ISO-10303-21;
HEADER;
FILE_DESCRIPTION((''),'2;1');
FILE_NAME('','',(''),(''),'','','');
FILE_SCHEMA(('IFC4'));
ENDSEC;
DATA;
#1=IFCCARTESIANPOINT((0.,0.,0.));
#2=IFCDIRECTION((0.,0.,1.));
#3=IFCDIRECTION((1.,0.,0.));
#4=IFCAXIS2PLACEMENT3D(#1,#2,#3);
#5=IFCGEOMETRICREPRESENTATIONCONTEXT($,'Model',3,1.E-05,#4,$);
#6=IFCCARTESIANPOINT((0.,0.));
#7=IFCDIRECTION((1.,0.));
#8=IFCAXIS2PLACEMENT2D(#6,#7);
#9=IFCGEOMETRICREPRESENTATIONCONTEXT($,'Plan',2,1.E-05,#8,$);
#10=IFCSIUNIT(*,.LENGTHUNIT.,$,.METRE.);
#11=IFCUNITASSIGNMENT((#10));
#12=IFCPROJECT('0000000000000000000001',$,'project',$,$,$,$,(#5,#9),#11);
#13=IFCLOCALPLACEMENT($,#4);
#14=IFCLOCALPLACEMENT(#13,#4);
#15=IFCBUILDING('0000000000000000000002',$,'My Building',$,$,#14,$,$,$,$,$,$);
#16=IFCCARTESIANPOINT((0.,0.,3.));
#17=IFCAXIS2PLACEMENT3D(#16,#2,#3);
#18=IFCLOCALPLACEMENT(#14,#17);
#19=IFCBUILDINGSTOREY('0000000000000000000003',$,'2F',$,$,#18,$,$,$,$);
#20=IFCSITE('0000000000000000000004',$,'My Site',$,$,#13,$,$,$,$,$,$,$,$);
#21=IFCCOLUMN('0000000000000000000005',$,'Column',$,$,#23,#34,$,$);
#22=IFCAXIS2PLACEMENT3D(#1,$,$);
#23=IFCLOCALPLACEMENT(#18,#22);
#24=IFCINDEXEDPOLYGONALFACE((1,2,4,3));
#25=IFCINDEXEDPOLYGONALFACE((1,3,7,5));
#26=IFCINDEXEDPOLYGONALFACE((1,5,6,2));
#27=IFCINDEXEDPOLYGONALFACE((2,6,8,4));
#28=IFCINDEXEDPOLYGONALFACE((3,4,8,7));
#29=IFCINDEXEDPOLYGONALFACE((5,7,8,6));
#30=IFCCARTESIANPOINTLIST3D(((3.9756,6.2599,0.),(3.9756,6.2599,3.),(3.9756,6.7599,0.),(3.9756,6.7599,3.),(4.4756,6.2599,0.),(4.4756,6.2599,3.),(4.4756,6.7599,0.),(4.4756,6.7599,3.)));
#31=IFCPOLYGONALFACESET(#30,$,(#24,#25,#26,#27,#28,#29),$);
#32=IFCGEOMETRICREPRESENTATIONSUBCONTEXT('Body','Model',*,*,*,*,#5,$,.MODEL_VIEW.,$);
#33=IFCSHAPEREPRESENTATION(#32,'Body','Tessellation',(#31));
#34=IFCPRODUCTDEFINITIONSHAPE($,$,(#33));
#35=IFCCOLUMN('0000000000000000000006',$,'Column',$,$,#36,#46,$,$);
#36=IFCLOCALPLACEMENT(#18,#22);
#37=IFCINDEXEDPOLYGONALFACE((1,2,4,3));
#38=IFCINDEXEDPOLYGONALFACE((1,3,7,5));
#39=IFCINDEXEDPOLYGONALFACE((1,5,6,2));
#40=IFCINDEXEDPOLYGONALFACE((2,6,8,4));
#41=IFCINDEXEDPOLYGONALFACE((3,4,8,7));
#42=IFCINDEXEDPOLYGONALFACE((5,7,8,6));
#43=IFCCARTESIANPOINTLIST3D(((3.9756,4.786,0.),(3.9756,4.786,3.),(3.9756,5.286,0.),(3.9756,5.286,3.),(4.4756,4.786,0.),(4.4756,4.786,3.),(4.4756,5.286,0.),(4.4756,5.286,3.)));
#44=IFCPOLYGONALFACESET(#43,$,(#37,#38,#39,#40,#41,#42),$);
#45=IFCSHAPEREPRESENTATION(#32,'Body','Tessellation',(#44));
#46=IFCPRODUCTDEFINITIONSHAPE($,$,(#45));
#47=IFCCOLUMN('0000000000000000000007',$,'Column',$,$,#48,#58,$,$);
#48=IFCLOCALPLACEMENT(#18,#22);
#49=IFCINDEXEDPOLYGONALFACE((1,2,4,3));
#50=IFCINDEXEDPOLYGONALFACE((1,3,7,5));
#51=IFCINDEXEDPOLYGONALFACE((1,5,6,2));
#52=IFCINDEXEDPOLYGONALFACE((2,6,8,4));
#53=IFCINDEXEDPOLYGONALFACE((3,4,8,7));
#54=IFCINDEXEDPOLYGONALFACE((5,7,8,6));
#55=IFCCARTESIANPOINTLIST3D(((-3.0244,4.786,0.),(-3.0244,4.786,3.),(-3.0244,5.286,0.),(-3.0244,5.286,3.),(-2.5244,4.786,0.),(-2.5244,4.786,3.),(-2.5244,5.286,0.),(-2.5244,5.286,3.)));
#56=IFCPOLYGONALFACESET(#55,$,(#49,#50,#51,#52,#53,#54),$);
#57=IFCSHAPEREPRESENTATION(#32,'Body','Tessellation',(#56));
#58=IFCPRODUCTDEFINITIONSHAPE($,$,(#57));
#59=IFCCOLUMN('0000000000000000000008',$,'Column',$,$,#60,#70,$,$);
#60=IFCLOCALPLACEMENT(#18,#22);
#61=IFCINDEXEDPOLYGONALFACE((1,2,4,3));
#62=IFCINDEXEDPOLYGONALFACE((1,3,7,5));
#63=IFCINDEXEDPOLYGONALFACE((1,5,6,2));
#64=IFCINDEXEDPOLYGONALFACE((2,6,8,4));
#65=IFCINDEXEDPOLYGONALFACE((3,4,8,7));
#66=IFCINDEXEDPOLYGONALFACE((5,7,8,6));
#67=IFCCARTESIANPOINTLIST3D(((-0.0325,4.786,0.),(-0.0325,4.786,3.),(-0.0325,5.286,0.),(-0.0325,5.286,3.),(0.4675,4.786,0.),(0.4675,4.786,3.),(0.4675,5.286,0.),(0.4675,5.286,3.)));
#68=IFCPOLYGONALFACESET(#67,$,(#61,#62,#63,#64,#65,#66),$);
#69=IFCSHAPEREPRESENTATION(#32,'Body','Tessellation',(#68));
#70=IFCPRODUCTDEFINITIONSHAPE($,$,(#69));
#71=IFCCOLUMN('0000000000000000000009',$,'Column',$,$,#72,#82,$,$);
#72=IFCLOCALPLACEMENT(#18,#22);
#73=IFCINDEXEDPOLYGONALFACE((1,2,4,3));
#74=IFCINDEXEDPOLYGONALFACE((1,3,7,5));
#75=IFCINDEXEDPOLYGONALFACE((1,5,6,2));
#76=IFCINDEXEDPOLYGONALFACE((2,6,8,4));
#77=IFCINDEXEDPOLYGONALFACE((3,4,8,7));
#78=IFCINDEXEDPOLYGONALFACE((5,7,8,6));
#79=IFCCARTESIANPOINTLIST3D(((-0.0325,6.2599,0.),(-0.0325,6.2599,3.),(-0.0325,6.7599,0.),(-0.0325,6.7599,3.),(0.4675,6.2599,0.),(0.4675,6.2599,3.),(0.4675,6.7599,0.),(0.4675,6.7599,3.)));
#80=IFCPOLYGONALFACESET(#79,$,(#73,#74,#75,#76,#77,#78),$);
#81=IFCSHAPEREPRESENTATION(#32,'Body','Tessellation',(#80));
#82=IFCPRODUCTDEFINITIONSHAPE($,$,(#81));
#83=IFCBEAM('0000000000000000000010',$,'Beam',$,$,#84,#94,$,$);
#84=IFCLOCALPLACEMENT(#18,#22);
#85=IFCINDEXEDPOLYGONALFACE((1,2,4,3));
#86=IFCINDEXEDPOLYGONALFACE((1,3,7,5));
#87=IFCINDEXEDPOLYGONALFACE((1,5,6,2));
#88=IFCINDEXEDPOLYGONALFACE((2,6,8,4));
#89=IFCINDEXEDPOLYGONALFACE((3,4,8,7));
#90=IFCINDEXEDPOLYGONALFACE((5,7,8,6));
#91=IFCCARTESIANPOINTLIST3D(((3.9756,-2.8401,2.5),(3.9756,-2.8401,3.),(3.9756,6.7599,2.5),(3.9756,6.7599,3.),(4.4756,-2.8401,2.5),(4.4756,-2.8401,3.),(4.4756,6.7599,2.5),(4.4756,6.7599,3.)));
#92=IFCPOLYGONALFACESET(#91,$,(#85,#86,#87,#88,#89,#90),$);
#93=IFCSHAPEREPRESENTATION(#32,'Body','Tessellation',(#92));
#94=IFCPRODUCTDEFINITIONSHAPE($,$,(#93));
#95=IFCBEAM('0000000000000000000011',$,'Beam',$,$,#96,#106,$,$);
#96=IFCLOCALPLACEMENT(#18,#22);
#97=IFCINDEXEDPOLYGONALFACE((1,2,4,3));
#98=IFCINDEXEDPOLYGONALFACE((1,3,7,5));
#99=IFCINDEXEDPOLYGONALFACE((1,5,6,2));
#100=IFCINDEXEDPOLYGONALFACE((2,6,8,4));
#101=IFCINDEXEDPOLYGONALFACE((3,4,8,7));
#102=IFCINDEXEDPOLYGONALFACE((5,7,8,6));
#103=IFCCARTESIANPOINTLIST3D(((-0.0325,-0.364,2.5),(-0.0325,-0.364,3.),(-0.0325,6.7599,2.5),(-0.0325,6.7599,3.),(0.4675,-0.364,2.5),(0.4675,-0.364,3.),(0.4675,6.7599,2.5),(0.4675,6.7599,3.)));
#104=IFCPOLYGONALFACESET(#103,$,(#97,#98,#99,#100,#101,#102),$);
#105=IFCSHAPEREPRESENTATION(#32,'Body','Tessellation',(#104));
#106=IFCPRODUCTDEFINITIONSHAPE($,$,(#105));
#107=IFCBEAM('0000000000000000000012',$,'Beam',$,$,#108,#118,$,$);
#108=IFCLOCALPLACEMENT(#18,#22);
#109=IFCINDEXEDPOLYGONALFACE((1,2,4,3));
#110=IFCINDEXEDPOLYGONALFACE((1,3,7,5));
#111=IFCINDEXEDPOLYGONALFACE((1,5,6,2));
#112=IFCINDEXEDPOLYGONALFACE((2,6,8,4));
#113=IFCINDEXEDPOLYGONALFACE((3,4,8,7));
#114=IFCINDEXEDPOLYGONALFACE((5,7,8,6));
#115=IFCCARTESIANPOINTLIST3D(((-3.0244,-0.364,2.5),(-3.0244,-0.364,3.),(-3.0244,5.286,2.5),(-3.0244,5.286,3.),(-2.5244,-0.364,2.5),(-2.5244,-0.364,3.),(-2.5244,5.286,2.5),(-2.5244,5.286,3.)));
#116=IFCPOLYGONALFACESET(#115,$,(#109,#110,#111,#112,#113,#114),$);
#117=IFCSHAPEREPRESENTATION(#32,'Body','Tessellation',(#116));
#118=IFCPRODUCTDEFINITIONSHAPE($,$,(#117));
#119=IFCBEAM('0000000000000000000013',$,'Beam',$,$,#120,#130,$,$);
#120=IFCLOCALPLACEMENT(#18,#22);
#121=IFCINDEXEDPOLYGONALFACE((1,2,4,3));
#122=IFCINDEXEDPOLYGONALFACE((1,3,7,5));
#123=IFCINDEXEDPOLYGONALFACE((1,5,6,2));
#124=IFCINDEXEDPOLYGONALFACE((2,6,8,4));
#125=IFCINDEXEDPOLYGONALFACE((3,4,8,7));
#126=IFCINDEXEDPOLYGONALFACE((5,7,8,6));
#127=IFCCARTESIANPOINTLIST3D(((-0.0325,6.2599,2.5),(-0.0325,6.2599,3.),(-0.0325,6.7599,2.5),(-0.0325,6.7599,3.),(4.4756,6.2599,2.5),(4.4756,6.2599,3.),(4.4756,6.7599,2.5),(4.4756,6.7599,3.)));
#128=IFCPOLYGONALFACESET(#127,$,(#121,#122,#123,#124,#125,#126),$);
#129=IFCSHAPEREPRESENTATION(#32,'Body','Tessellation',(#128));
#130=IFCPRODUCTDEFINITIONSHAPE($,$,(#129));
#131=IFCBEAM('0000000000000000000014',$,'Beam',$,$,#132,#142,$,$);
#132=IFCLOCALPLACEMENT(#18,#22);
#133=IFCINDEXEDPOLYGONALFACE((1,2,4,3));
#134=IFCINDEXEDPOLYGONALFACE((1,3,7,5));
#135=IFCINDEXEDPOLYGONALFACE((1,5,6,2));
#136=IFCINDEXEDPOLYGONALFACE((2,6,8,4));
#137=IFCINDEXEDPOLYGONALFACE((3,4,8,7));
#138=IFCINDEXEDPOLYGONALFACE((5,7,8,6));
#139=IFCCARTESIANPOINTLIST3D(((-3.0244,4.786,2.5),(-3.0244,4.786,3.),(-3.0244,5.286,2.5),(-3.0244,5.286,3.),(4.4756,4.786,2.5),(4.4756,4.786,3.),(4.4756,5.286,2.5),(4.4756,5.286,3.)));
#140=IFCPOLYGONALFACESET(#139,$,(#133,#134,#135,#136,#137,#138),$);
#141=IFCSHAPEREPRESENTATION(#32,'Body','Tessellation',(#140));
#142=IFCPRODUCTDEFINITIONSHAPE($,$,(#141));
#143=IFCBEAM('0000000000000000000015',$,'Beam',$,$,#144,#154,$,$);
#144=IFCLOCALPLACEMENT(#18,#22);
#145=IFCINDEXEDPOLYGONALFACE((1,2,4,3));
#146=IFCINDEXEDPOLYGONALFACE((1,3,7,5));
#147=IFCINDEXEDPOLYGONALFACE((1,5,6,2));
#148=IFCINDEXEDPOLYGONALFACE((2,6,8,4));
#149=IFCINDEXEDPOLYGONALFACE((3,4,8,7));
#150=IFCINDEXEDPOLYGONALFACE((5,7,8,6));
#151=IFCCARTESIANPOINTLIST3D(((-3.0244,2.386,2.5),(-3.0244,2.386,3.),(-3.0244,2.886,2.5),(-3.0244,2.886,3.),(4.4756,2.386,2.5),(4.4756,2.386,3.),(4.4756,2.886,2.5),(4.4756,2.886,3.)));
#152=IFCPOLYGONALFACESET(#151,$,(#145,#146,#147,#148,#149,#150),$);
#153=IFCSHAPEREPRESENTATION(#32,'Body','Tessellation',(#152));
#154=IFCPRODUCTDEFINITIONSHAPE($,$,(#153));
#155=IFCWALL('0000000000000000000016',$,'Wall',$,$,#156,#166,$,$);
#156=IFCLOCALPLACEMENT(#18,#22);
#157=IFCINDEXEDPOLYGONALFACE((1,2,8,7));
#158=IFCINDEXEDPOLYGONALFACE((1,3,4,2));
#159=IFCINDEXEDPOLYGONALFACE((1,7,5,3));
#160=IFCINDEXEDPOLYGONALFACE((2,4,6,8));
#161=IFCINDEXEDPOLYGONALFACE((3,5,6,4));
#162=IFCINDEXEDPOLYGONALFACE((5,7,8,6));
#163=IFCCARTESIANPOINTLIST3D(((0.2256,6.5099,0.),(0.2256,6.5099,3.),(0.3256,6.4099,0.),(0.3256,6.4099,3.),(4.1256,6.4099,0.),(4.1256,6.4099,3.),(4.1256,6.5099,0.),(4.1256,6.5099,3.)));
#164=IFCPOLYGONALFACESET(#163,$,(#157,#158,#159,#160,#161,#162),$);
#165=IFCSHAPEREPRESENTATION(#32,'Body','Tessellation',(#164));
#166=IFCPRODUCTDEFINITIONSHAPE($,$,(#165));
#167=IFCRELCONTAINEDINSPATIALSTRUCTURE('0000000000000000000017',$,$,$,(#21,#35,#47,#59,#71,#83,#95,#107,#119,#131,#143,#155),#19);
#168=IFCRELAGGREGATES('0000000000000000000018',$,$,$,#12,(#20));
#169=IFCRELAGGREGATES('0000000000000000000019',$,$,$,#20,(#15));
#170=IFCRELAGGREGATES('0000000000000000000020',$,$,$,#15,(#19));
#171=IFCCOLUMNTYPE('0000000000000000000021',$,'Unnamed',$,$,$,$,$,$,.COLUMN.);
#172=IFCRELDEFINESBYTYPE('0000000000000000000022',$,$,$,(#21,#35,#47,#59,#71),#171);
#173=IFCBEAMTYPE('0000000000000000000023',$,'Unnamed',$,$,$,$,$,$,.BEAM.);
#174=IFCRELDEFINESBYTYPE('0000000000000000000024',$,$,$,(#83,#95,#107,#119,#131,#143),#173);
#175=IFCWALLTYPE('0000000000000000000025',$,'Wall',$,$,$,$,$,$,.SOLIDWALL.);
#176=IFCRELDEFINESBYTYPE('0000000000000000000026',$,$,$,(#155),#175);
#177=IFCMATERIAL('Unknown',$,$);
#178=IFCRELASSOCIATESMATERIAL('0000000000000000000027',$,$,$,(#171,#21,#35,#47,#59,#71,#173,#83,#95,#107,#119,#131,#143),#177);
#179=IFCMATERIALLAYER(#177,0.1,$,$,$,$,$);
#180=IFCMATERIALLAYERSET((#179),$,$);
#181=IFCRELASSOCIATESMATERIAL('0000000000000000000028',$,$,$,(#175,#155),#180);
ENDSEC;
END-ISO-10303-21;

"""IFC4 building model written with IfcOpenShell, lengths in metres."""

from ifc_helpers import new_model, si_unit, frame, origin_with_axes, origin_2d_with_axis, place, context, subcontext, project, spatial, line, indexed_curve, rectangle, outline, extrude, material, layer, layer_set, layer_usage, material_profile, profile_set, profile_usage, type_object, element, save


model = new_model("IFC4")

# Units and contexts
model_context = context("Model", 3, precision=1e-05, world=origin_with_axes())
plan_context = context("Plan", 2, precision=1e-05, world=origin_2d_with_axis())
body_context_1 = subcontext(model_context, "Body", "Model", "MODEL_VIEW")
ifc_project = project(units=[si_unit("LENGTHUNIT", "METRE")], contexts=[model_context, plan_context])

# Site, building, storey
site_placement = place(None, origin_with_axes())
site = spatial("IfcSite", under=ifc_project, at=site_placement, Name="My Site")
building_placement = place(site_placement, origin_with_axes())
building = spatial("IfcBuilding", under=site, at=building_placement, Name="My Building")
storey_placement = place(building_placement, frame((0.0, 0.0, 3.0), z_axis=(0.0, 0.0, 1.0), x_axis=(1.0, 0.0, 0.0)))
storey = spatial("IfcBuildingStorey", under=building, at=storey_placement, Name="2F")

# Columns
ifc_material = material(Name="Unknown")
ifc_material_profile_1 = material_profile(ifc_material, rectangle(XDim=0.5, YDim=0.5))
ifc_profile_set_1 = profile_set([ifc_material_profile_1])
ifc_profile_usage_1 = profile_usage(ifc_profile_set_1, cardinal=5)
column_type = type_object("IfcColumnType", Name="Unnamed", PredefinedType="COLUMN", material=ifc_profile_set_1)
column_1_placement = place(storey_placement, frame((4.2256, 6.5099, 0.0), z_axis=(0.0, 0.0, 1.0), x_axis=(1.0, 0.0, 0.0)))
element("IfcColumn", 1, at=column_1_placement, inside=storey, type_object=column_type, material=ifc_profile_usage_1, Name="Column", context=body_context_1, shape_type="SweptSolid", body=[
    extrude(rectangle(XDim=0.5, YDim=0.5), origin_with_axes(), (0.0, 0.0, 1.0), 3.0),
])
ifc_profile_usage_2 = profile_usage(ifc_profile_set_1, cardinal=5)
column_2_placement = place(storey_placement, frame((4.2256, 5.036, 0.0), z_axis=(0.0, 0.0, 1.0), x_axis=(1.0, 0.0, 0.0)))
element("IfcColumn", 2, at=column_2_placement, inside=storey, type_object=column_type, material=ifc_profile_usage_2, Name="Column", context=body_context_1, shape_type="SweptSolid", body=[
    extrude(rectangle(XDim=0.5, YDim=0.5), origin_with_axes(), (0.0, 0.0, 1.0), 3.0),
])
ifc_profile_usage_3 = profile_usage(ifc_profile_set_1, cardinal=5)
column_3_placement = place(storey_placement, frame((-2.7744, 5.036, 0.0), z_axis=(0.0, 0.0, 1.0), x_axis=(1.0, 0.0, 0.0)))
element("IfcColumn", 3, at=column_3_placement, inside=storey, type_object=column_type, material=ifc_profile_usage_3, Name="Column", context=body_context_1, shape_type="SweptSolid", body=[
    extrude(rectangle(XDim=0.5, YDim=0.5), origin_with_axes(), (0.0, 0.0, 1.0), 3.0),
])
ifc_profile_usage_4 = profile_usage(ifc_profile_set_1, cardinal=5)
column_4_placement = place(storey_placement, frame((0.2175, 5.036, 0.0), z_axis=(0.0, 0.0, 1.0), x_axis=(1.0, 0.0, 0.0)))
element("IfcColumn", 4, at=column_4_placement, inside=storey, type_object=column_type, material=ifc_profile_usage_4, Name="Column", context=body_context_1, shape_type="SweptSolid", body=[
    extrude(rectangle(XDim=0.5, YDim=0.5), origin_with_axes(), (0.0, 0.0, 1.0), 3.0),
])
ifc_profile_usage_5 = profile_usage(ifc_profile_set_1, cardinal=5)
column_5_placement = place(storey_placement, frame((0.2175, 6.5099, 0.0), z_axis=(0.0, 0.0, 1.0), x_axis=(1.0, 0.0, 0.0)))
element("IfcColumn", 5, at=column_5_placement, inside=storey, type_object=column_type, material=ifc_profile_usage_5, Name="Column", context=body_context_1, shape_type="SweptSolid", body=[
    extrude(rectangle(XDim=0.5, YDim=0.5), origin_with_axes(), (0.0, 0.0, 1.0), 3.0),
])

# Beams
ifc_material_profile_2 = material_profile(ifc_material, rectangle(XDim=0.5, YDim=0.5))
ifc_profile_set_2 = profile_set([ifc_material_profile_2])
ifc_profile_usage_6 = profile_usage(ifc_profile_set_2, cardinal=7)
beam_type = type_object("IfcBeamType", Name="Unnamed", PredefinedType="BEAM", material=ifc_profile_set_2)
beam_1_placement = place(storey_placement, frame((4.4756, 6.7599, 3.0), z_axis=(0.0, -1.0, 0.0), x_axis=(1.0, 0.0, 0.0)))
element("IfcBeam", 6, at=beam_1_placement, inside=storey, type_object=beam_type, material=ifc_profile_usage_6, Name="Beam", context=body_context_1, shape_type="SweptSolid", body=[
    extrude(rectangle(XDim=0.5, YDim=0.5), frame((-0.25, -0.25, 0.0), z_axis=(0.0, 0.0, 1.0), x_axis=(1.0, 0.0, 0.0)), (0.0, 0.0, 1.0), 9.6),
])
ifc_profile_usage_7 = profile_usage(ifc_profile_set_2, cardinal=7)
beam_2_placement = place(storey_placement, frame((0.4675, 6.7599, 3.0), z_axis=(0.0, -1.0, 0.0), x_axis=(1.0, 0.0, 0.0)))
element("IfcBeam", 7, at=beam_2_placement, inside=storey, type_object=beam_type, material=ifc_profile_usage_7, Name="Beam", context=body_context_1, shape_type="SweptSolid", body=[
    extrude(rectangle(XDim=0.5, YDim=0.5), frame((-0.25, -0.25, 0.0), z_axis=(0.0, 0.0, 1.0), x_axis=(1.0, 0.0, 0.0)), (0.0, 0.0, 1.0), 7.1239),
])
ifc_profile_usage_8 = profile_usage(ifc_profile_set_2, cardinal=7)
beam_3_placement = place(storey_placement, frame((-2.5244, 5.286, 3.0), z_axis=(0.0, -1.0, 0.0), x_axis=(1.0, 0.0, 0.0)))
element("IfcBeam", 8, at=beam_3_placement, inside=storey, type_object=beam_type, material=ifc_profile_usage_8, Name="Beam", context=body_context_1, shape_type="SweptSolid", body=[
    extrude(rectangle(XDim=0.5, YDim=0.5), frame((-0.25, -0.25, 0.0), z_axis=(0.0, 0.0, 1.0), x_axis=(1.0, 0.0, 0.0)), (0.0, 0.0, 1.0), 5.65),
])
ifc_profile_usage_9 = profile_usage(ifc_profile_set_2, cardinal=7)
beam_4_placement = place(storey_placement, frame((-0.0325, 6.7599, 3.0), z_axis=(1.0, 0.0, 0.0), x_axis=(0.0, 1.0, 0.0)))
element("IfcBeam", 9, at=beam_4_placement, inside=storey, type_object=beam_type, material=ifc_profile_usage_9, Name="Beam", context=body_context_1, shape_type="SweptSolid", body=[
    extrude(rectangle(XDim=0.5, YDim=0.5), frame((-0.25, -0.25, 0.0), z_axis=(0.0, 0.0, 1.0), x_axis=(1.0, 0.0, 0.0)), (0.0, 0.0, 1.0), 4.5081),
])
ifc_profile_usage_10 = profile_usage(ifc_profile_set_2, cardinal=7)
beam_5_placement = place(storey_placement, frame((-3.0244, 5.286, 3.0), z_axis=(1.0, 0.0, 0.0), x_axis=(0.0, 1.0, 0.0)))
element("IfcBeam", 10, at=beam_5_placement, inside=storey, type_object=beam_type, material=ifc_profile_usage_10, Name="Beam", context=body_context_1, shape_type="SweptSolid", body=[
    extrude(rectangle(XDim=0.5, YDim=0.5), frame((-0.25, -0.25, 0.0), z_axis=(0.0, 0.0, 1.0), x_axis=(1.0, 0.0, 0.0)), (0.0, 0.0, 1.0), 7.5),
])
ifc_profile_usage_11 = profile_usage(ifc_profile_set_2, cardinal=7)
beam_6_placement = place(storey_placement, frame((-3.0244, 2.886, 3.0), z_axis=(1.0, 0.0, 0.0), x_axis=(0.0, 1.0, 0.0)))
element("IfcBeam", 11, at=beam_6_placement, inside=storey, type_object=beam_type, material=ifc_profile_usage_11, Name="Beam", context=body_context_1, shape_type="SweptSolid", body=[
    extrude(rectangle(XDim=0.5, YDim=0.5), frame((-0.25, -0.25, 0.0), z_axis=(0.0, 0.0, 1.0), x_axis=(1.0, 0.0, 0.0)), (0.0, 0.0, 1.0), 7.5),
])

# Wall
ifc_layer = layer(ifc_material, 0.1)
ifc_layer_set = layer_set([ifc_layer])
ifc_layer_usage_1 = layer_usage(ifc_layer_set, "AXIS2", "POSITIVE", 0.0)
wall_type = type_object("IfcWallType", Name="Wall", PredefinedType="SOLIDWALL", material=ifc_layer_set)
wall_1_placement = place(storey_placement, frame((4.1256, 6.5099, 0.0), z_axis=(0.0, 0.0, 1.0), x_axis=(-1.0, 0.0, 0.0)))
element("IfcWall", 12, at=wall_1_placement, inside=storey, type_object=wall_type, material=ifc_layer_usage_1, Name="Wall", context=body_context_1, shape_type="SweptSolid", body=[
    extrude(outline(indexed_curve([(0.0, 0.0), (0.0, 0.1), (3.8, 0.1), (3.9, 0.0)], segments=[line(1, 2, 3, 4, 1)])), origin_with_axes(), (0.0, 0.0, 1.0), 3.0),
])

save(model, "model.ifc")
